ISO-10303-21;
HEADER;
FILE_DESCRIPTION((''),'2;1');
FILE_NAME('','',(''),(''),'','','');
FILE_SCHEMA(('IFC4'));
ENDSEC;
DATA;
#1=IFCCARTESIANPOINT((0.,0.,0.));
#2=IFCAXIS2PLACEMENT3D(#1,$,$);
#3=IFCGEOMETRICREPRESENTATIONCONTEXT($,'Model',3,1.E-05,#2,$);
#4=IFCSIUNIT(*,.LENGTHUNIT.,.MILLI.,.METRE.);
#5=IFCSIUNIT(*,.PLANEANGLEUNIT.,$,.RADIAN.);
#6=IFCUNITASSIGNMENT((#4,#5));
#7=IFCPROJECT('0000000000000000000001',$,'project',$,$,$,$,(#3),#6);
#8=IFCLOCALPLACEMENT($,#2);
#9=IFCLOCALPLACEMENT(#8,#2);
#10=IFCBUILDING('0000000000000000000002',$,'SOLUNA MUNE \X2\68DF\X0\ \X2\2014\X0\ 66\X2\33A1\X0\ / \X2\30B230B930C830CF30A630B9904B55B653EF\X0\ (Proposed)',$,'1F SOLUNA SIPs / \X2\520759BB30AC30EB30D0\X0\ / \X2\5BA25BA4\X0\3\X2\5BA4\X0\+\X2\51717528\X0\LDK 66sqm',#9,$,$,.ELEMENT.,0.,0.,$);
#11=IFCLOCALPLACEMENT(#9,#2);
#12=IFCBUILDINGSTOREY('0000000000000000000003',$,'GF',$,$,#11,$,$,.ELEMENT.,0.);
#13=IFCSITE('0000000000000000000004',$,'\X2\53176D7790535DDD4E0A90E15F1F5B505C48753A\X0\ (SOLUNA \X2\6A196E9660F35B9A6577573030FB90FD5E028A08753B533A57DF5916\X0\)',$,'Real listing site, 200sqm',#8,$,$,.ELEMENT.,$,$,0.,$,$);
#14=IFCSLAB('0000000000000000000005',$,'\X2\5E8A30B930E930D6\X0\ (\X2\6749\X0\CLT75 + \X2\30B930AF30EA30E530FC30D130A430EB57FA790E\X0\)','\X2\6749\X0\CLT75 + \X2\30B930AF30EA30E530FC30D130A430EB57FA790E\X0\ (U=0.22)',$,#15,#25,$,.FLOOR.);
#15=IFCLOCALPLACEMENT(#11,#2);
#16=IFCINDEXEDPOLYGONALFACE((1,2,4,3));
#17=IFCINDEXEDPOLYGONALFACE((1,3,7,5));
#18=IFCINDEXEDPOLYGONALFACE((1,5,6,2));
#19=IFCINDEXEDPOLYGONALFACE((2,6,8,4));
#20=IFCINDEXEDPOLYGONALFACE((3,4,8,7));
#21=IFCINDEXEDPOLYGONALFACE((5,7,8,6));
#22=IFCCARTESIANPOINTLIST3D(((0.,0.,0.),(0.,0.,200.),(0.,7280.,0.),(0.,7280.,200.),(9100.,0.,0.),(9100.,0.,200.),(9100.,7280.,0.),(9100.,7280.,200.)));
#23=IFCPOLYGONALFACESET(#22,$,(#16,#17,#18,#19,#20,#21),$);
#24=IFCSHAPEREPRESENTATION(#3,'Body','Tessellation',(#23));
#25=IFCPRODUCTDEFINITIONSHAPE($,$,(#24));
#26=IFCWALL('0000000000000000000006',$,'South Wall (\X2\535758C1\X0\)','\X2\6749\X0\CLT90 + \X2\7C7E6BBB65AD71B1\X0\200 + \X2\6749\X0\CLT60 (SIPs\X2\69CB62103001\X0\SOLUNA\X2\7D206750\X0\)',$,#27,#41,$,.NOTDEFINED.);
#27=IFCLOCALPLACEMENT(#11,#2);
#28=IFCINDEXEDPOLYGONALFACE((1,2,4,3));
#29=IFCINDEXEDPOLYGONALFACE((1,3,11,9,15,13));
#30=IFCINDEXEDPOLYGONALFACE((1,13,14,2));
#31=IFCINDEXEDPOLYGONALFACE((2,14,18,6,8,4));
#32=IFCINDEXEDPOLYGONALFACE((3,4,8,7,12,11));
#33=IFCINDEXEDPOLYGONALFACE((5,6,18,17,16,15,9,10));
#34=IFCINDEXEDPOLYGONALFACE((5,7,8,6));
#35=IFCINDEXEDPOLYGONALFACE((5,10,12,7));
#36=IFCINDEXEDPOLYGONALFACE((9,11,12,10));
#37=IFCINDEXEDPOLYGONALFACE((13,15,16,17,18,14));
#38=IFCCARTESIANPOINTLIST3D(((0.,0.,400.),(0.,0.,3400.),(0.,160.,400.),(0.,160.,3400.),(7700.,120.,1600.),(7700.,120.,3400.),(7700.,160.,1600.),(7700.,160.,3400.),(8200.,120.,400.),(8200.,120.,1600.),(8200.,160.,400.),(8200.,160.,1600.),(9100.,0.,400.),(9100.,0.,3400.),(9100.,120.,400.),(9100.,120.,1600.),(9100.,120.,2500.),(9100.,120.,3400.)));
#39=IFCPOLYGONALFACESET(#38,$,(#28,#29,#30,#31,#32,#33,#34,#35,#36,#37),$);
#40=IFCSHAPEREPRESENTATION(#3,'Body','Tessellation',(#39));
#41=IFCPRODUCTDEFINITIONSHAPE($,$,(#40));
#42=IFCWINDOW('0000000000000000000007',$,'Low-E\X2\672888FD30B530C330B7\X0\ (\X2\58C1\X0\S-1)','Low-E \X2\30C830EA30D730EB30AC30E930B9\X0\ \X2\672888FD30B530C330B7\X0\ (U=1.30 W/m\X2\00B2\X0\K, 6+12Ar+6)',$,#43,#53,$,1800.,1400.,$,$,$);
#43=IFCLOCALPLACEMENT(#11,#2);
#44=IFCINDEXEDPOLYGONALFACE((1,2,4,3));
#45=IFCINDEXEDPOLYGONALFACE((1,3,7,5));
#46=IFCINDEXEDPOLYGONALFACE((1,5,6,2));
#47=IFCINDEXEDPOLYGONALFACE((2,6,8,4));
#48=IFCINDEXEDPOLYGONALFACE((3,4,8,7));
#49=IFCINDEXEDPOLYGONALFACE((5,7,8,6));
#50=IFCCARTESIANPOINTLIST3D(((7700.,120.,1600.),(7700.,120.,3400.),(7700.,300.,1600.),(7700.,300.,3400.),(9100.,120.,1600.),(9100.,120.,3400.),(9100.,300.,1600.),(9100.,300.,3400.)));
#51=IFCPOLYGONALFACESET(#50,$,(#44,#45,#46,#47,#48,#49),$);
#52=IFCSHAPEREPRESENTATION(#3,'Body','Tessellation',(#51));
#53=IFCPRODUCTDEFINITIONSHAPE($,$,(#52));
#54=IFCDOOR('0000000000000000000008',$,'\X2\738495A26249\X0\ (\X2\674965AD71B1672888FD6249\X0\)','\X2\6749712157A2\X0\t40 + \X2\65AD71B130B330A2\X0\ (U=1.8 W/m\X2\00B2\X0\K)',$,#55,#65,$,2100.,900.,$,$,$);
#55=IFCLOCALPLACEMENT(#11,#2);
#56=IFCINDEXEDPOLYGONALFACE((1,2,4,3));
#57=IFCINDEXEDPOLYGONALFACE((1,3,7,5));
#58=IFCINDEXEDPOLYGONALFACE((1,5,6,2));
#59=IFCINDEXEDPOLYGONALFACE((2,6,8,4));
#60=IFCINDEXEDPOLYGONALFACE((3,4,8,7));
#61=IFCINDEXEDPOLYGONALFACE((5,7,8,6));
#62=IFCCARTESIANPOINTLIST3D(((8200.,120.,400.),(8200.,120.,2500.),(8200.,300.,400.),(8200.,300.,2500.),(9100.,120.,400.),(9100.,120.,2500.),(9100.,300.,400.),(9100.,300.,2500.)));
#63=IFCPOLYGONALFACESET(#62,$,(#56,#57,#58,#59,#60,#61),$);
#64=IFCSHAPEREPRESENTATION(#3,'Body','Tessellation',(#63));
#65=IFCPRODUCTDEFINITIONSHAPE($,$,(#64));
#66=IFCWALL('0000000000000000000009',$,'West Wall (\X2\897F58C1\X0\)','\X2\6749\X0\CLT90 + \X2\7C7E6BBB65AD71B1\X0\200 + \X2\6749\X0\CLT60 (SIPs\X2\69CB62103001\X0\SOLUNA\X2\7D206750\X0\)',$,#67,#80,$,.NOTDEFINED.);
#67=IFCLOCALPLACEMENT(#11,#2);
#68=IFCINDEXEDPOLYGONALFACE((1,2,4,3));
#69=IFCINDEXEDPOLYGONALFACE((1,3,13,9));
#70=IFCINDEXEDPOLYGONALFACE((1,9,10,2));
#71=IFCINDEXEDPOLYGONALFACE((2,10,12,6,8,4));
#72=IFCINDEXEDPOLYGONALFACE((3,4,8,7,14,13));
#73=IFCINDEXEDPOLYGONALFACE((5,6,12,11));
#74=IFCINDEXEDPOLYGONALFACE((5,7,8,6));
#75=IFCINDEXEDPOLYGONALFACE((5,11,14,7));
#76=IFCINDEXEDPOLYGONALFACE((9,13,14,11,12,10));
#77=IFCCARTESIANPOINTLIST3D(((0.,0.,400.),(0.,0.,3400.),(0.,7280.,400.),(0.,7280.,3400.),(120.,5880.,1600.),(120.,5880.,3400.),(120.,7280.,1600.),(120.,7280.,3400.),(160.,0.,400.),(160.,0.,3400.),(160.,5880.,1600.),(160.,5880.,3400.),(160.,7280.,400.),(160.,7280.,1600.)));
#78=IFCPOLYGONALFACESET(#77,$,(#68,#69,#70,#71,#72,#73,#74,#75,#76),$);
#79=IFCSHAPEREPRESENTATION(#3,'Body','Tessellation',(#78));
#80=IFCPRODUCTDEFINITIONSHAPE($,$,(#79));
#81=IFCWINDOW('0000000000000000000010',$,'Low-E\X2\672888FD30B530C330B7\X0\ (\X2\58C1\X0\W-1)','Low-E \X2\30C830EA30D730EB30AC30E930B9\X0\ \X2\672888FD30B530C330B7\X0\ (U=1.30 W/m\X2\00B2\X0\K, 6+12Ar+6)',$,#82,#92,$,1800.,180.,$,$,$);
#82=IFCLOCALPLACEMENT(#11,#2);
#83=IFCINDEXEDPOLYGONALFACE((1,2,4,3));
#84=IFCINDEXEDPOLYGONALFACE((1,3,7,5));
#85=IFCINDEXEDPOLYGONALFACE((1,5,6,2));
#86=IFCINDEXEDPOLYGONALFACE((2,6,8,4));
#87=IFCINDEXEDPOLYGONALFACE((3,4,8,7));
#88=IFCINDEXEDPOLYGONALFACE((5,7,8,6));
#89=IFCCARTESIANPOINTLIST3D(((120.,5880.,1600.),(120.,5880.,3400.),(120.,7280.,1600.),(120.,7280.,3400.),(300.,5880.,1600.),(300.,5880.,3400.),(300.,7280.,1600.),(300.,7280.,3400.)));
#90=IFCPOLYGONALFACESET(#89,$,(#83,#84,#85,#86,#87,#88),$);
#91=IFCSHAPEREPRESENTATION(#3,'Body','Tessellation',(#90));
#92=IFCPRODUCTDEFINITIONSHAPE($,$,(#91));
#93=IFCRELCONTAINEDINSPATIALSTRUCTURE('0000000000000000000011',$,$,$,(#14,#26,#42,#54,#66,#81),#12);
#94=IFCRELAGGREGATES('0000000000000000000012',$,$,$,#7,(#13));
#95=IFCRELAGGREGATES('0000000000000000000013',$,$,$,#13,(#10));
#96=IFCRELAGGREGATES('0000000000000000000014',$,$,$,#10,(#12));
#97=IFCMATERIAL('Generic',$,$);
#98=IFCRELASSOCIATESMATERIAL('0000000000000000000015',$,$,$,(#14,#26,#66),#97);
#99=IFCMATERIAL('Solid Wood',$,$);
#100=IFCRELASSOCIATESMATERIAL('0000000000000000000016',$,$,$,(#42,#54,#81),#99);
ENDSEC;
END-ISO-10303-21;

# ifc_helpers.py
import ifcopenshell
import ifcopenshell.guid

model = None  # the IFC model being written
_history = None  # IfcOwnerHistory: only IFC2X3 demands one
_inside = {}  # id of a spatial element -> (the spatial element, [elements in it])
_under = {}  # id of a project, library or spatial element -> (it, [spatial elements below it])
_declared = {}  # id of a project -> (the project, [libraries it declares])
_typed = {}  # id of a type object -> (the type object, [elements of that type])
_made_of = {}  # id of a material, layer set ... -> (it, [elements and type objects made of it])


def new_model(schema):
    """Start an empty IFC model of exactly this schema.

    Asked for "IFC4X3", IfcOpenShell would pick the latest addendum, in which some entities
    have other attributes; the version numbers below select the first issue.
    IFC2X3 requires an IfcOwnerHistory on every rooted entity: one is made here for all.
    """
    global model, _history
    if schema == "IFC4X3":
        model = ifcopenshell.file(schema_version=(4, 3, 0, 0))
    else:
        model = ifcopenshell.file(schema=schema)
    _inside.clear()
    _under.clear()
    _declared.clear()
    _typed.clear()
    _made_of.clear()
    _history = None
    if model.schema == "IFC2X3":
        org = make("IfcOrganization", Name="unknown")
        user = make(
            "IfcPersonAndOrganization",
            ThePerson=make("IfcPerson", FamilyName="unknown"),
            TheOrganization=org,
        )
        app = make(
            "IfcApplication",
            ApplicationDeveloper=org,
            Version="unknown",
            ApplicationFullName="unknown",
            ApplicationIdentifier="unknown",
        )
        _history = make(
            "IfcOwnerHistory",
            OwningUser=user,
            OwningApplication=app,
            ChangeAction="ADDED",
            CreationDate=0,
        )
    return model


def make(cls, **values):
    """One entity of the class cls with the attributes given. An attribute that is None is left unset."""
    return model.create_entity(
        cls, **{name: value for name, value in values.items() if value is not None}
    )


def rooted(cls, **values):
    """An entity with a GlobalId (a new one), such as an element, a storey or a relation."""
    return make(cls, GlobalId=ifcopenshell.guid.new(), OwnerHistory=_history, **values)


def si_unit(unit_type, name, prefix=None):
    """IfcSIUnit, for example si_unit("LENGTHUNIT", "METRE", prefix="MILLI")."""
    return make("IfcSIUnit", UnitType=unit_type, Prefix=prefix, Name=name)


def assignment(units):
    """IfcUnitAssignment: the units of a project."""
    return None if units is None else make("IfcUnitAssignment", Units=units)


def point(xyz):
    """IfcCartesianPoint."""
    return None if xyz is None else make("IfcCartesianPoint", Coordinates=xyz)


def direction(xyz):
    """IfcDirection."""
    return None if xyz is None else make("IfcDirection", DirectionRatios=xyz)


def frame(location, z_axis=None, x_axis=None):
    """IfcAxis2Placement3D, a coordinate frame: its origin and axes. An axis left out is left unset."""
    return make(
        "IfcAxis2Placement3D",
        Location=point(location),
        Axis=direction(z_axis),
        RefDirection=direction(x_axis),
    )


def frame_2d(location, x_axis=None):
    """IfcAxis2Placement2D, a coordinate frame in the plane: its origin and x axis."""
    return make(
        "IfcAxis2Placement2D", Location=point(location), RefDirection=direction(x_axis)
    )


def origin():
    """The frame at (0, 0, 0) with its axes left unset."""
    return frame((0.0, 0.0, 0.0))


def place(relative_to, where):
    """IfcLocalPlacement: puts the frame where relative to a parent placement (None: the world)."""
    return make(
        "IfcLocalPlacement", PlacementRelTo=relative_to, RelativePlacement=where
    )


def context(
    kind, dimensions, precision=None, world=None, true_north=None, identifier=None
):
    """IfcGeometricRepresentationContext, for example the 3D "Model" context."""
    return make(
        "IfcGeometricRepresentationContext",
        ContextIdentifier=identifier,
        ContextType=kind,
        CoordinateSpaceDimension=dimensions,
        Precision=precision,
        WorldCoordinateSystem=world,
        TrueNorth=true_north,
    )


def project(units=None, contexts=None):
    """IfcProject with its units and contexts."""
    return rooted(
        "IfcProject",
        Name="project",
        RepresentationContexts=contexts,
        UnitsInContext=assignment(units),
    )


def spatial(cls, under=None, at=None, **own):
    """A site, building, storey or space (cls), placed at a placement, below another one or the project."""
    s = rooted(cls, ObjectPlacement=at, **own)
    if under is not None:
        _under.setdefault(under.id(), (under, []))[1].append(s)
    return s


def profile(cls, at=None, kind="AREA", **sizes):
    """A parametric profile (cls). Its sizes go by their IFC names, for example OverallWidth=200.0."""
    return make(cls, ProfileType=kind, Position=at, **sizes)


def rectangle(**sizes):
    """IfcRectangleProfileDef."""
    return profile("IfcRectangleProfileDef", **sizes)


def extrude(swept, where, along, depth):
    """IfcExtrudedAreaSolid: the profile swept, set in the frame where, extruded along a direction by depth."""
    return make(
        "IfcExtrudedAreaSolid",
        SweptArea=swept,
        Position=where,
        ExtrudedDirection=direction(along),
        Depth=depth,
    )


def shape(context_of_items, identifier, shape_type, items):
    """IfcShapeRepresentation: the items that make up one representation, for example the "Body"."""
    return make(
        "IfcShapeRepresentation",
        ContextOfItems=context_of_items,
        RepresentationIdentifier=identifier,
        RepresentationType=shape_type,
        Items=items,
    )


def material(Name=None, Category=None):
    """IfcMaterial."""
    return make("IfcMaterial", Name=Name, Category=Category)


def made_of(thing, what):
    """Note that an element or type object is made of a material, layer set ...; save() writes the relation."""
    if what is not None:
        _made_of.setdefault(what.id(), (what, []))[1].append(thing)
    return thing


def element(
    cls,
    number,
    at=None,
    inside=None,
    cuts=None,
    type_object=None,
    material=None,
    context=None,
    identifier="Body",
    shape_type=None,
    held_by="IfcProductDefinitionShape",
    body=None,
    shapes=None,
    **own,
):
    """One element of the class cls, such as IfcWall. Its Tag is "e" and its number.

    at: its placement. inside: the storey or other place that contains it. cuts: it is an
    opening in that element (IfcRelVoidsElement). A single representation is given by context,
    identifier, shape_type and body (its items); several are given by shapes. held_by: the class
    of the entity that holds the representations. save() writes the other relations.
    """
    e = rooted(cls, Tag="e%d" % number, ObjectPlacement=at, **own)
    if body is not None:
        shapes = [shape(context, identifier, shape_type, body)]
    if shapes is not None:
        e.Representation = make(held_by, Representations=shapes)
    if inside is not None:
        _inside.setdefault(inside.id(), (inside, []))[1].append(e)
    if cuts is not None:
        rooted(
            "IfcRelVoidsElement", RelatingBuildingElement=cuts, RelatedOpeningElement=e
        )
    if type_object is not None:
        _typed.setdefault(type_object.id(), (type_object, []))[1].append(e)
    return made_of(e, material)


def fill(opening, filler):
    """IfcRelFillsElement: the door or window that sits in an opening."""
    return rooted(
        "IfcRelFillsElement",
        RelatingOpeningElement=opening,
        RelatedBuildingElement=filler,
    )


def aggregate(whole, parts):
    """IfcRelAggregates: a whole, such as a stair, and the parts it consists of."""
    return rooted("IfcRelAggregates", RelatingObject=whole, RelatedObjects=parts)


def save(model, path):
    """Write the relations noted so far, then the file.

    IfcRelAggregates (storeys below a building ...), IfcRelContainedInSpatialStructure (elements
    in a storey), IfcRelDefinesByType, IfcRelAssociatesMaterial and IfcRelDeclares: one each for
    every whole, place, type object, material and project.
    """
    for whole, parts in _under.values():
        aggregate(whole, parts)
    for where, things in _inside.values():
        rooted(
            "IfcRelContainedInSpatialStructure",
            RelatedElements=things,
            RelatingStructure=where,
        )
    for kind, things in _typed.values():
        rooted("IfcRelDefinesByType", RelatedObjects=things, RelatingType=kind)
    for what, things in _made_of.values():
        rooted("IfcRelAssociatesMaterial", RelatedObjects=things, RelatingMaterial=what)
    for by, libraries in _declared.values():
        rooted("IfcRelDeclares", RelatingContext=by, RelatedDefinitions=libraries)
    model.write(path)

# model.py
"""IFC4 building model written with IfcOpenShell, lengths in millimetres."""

from ifc_helpers import new_model, si_unit, frame, frame_2d, origin, place, context, project, spatial, rectangle, extrude, material, element, fill, save


model = new_model("IFC4")

# Units and contexts
model_context = context("Model", 3, precision=1e-05, world=origin())
ifc_project = project(units=[si_unit("LENGTHUNIT", "METRE", prefix="MILLI"), si_unit("PLANEANGLEUNIT", "RADIAN")], contexts=[model_context])

# Site, building, storey
site_placement = place(None, origin())
site = spatial("IfcSite", under=ifc_project, at=site_placement, Name="北海道川上郡弟子屈町 (SOLUNA 標準想定敷地・都市計画区域外)", ObjectType="Real listing site, 200sqm", CompositionType="ELEMENT", RefElevation=0.0)
building_placement = place(site_placement, origin())
building = spatial("IfcBuilding", under=site, at=building_placement, Name="SOLUNA MUNE 棟 — 66㎡ / ゲストハウス運営可 (Proposed)", ObjectType="1F SOLUNA SIPs / 切妻ガルバ / 客室3室+共用LDK 66sqm", CompositionType="ELEMENT", ElevationOfRefHeight=0.0, ElevationOfTerrain=0.0)
storey_placement = place(building_placement, origin())
storey = spatial("IfcBuildingStorey", under=building, at=storey_placement, Name="GF", CompositionType="ELEMENT", Elevation=0.0)

# Slab
ifc_material_1 = material(Name="Generic")
slab_placement = place(storey_placement, origin())
element("IfcSlab", 1, at=slab_placement, inside=storey, material=ifc_material_1, Name="床スラブ (杉CLT75 + スクリューパイル基礎)", Description="杉CLT75 + スクリューパイル基礎 (U=0.22)", PredefinedType="FLOOR", context=model_context, shape_type="SweptSolid", body=[
    extrude(rectangle(XDim=9100.0, YDim=7280.0, at=frame_2d((4550.0, 3640.0))), origin(), (0.0, 0.0, 1.0), 200.0),
])

# Wall, openings, window, door
wall_1_placement = place(storey_placement, frame((0.0, 0.0, 200.0)))
wall_1 = element("IfcWall", 2, at=wall_1_placement, inside=storey, material=ifc_material_1, Name="South Wall (南壁)", Description="杉CLT90 + 籾殻断熱200 + 杉CLT60 (SIPs構成、SOLUNA素材)", PredefinedType="NOTDEFINED", context=model_context, shape_type="SweptSolid", body=[
    extrude(rectangle(XDim=9100.0, YDim=160.0, at=frame_2d((4550.0, 80.0))), frame((0.0, 0.0, 200.0)), (0.0, 0.0, 1.0), 3000.0),
])
opening_1_placement = place(storey_placement, frame((3850.0, 60.0, 800.0)))
opening_1 = element("IfcOpeningElement", 3, at=opening_1_placement, cuts=wall_1, PredefinedType="NOTDEFINED", context=model_context, shape_type="SweptSolid", body=[
    extrude(rectangle(XDim=1400.0, YDim=180.0, at=frame_2d((700.0, 90.0))), frame((3850.0, 60.0, 800.0)), (0.0, 0.0, 1.0), 1800.0),
])
opening_2_placement = place(storey_placement, frame((4100.0, 60.0, 200.0)))
opening_2 = element("IfcOpeningElement", 4, at=opening_2_placement, cuts=wall_1, PredefinedType="NOTDEFINED", context=model_context, shape_type="SweptSolid", body=[
    extrude(rectangle(XDim=900.0, YDim=180.0, at=frame_2d((450.0, 90.0))), frame((4100.0, 60.0, 200.0)), (0.0, 0.0, 1.0), 2100.0),
])
ifc_material_2 = material(Name="Solid Wood")
window_1_placement = place(storey_placement, frame((3850.0, 60.0, 800.0)))
window_1 = element("IfcWindow", 5, at=window_1_placement, inside=storey, material=ifc_material_2, Name="Low-E木製サッシ (壁S-1)", Description="Low-E トリプルガラス 木製サッシ (U=1.30 W/m²K, 6+12Ar+6)", OverallHeight=1800.0, OverallWidth=1400.0, context=model_context, shape_type="SweptSolid", body=[
    extrude(rectangle(XDim=1400.0, YDim=180.0, at=frame_2d((700.0, 90.0))), frame((3850.0, 60.0, 800.0)), (0.0, 0.0, 1.0), 1800.0),
])
fill(opening_1, window_1)
door_placement = place(storey_placement, frame((4100.0, 60.0, 200.0)))
door = element("IfcDoor", 6, at=door_placement, inside=storey, material=ifc_material_2, Name="玄関扉 (杉断熱木製扉)", Description="杉無垢t40 + 断熱コア (U=1.8 W/m²K)", OverallHeight=2100.0, OverallWidth=900.0, context=model_context, shape_type="SweptSolid", body=[
    extrude(rectangle(XDim=900.0, YDim=180.0, at=frame_2d((450.0, 90.0))), frame((4100.0, 60.0, 200.0)), (0.0, 0.0, 1.0), 2100.0),
])
fill(opening_2, door)

# Wall, opening, window
wall_2_placement = place(storey_placement, frame((0.0, 0.0, 200.0)))
wall_2 = element("IfcWall", 7, at=wall_2_placement, inside=storey, material=ifc_material_1, Name="West Wall (西壁)", Description="杉CLT90 + 籾殻断熱200 + 杉CLT60 (SIPs構成、SOLUNA素材)", PredefinedType="NOTDEFINED", context=model_context, shape_type="SweptSolid", body=[
    extrude(rectangle(XDim=160.0, YDim=7280.0, at=frame_2d((80.0, 3640.0))), frame((0.0, 0.0, 200.0)), (0.0, 0.0, 1.0), 3000.0),
])
opening_3_placement = place(storey_placement, frame((60.0, 2940.0, 800.0)))
opening_3 = element("IfcOpeningElement", 8, at=opening_3_placement, cuts=wall_2, PredefinedType="NOTDEFINED", context=model_context, shape_type="SweptSolid", body=[
    extrude(rectangle(XDim=180.0, YDim=1400.0, at=frame_2d((90.0, 700.0))), frame((60.0, 2940.0, 800.0)), (0.0, 0.0, 1.0), 1800.0),
])
window_2_placement = place(storey_placement, frame((60.0, 2940.0, 800.0)))
window_2 = element("IfcWindow", 9, at=window_2_placement, inside=storey, material=ifc_material_2, Name="Low-E木製サッシ (壁W-1)", Description="Low-E トリプルガラス 木製サッシ (U=1.30 W/m²K, 6+12Ar+6)", OverallHeight=1800.0, OverallWidth=180.0, context=model_context, shape_type="SweptSolid", body=[
    extrude(rectangle(XDim=180.0, YDim=1400.0, at=frame_2d((90.0, 700.0))), frame((60.0, 2940.0, 800.0)), (0.0, 0.0, 1.0), 1800.0),
])
fill(opening_3, window_2)

save(model, "model.ifc")
